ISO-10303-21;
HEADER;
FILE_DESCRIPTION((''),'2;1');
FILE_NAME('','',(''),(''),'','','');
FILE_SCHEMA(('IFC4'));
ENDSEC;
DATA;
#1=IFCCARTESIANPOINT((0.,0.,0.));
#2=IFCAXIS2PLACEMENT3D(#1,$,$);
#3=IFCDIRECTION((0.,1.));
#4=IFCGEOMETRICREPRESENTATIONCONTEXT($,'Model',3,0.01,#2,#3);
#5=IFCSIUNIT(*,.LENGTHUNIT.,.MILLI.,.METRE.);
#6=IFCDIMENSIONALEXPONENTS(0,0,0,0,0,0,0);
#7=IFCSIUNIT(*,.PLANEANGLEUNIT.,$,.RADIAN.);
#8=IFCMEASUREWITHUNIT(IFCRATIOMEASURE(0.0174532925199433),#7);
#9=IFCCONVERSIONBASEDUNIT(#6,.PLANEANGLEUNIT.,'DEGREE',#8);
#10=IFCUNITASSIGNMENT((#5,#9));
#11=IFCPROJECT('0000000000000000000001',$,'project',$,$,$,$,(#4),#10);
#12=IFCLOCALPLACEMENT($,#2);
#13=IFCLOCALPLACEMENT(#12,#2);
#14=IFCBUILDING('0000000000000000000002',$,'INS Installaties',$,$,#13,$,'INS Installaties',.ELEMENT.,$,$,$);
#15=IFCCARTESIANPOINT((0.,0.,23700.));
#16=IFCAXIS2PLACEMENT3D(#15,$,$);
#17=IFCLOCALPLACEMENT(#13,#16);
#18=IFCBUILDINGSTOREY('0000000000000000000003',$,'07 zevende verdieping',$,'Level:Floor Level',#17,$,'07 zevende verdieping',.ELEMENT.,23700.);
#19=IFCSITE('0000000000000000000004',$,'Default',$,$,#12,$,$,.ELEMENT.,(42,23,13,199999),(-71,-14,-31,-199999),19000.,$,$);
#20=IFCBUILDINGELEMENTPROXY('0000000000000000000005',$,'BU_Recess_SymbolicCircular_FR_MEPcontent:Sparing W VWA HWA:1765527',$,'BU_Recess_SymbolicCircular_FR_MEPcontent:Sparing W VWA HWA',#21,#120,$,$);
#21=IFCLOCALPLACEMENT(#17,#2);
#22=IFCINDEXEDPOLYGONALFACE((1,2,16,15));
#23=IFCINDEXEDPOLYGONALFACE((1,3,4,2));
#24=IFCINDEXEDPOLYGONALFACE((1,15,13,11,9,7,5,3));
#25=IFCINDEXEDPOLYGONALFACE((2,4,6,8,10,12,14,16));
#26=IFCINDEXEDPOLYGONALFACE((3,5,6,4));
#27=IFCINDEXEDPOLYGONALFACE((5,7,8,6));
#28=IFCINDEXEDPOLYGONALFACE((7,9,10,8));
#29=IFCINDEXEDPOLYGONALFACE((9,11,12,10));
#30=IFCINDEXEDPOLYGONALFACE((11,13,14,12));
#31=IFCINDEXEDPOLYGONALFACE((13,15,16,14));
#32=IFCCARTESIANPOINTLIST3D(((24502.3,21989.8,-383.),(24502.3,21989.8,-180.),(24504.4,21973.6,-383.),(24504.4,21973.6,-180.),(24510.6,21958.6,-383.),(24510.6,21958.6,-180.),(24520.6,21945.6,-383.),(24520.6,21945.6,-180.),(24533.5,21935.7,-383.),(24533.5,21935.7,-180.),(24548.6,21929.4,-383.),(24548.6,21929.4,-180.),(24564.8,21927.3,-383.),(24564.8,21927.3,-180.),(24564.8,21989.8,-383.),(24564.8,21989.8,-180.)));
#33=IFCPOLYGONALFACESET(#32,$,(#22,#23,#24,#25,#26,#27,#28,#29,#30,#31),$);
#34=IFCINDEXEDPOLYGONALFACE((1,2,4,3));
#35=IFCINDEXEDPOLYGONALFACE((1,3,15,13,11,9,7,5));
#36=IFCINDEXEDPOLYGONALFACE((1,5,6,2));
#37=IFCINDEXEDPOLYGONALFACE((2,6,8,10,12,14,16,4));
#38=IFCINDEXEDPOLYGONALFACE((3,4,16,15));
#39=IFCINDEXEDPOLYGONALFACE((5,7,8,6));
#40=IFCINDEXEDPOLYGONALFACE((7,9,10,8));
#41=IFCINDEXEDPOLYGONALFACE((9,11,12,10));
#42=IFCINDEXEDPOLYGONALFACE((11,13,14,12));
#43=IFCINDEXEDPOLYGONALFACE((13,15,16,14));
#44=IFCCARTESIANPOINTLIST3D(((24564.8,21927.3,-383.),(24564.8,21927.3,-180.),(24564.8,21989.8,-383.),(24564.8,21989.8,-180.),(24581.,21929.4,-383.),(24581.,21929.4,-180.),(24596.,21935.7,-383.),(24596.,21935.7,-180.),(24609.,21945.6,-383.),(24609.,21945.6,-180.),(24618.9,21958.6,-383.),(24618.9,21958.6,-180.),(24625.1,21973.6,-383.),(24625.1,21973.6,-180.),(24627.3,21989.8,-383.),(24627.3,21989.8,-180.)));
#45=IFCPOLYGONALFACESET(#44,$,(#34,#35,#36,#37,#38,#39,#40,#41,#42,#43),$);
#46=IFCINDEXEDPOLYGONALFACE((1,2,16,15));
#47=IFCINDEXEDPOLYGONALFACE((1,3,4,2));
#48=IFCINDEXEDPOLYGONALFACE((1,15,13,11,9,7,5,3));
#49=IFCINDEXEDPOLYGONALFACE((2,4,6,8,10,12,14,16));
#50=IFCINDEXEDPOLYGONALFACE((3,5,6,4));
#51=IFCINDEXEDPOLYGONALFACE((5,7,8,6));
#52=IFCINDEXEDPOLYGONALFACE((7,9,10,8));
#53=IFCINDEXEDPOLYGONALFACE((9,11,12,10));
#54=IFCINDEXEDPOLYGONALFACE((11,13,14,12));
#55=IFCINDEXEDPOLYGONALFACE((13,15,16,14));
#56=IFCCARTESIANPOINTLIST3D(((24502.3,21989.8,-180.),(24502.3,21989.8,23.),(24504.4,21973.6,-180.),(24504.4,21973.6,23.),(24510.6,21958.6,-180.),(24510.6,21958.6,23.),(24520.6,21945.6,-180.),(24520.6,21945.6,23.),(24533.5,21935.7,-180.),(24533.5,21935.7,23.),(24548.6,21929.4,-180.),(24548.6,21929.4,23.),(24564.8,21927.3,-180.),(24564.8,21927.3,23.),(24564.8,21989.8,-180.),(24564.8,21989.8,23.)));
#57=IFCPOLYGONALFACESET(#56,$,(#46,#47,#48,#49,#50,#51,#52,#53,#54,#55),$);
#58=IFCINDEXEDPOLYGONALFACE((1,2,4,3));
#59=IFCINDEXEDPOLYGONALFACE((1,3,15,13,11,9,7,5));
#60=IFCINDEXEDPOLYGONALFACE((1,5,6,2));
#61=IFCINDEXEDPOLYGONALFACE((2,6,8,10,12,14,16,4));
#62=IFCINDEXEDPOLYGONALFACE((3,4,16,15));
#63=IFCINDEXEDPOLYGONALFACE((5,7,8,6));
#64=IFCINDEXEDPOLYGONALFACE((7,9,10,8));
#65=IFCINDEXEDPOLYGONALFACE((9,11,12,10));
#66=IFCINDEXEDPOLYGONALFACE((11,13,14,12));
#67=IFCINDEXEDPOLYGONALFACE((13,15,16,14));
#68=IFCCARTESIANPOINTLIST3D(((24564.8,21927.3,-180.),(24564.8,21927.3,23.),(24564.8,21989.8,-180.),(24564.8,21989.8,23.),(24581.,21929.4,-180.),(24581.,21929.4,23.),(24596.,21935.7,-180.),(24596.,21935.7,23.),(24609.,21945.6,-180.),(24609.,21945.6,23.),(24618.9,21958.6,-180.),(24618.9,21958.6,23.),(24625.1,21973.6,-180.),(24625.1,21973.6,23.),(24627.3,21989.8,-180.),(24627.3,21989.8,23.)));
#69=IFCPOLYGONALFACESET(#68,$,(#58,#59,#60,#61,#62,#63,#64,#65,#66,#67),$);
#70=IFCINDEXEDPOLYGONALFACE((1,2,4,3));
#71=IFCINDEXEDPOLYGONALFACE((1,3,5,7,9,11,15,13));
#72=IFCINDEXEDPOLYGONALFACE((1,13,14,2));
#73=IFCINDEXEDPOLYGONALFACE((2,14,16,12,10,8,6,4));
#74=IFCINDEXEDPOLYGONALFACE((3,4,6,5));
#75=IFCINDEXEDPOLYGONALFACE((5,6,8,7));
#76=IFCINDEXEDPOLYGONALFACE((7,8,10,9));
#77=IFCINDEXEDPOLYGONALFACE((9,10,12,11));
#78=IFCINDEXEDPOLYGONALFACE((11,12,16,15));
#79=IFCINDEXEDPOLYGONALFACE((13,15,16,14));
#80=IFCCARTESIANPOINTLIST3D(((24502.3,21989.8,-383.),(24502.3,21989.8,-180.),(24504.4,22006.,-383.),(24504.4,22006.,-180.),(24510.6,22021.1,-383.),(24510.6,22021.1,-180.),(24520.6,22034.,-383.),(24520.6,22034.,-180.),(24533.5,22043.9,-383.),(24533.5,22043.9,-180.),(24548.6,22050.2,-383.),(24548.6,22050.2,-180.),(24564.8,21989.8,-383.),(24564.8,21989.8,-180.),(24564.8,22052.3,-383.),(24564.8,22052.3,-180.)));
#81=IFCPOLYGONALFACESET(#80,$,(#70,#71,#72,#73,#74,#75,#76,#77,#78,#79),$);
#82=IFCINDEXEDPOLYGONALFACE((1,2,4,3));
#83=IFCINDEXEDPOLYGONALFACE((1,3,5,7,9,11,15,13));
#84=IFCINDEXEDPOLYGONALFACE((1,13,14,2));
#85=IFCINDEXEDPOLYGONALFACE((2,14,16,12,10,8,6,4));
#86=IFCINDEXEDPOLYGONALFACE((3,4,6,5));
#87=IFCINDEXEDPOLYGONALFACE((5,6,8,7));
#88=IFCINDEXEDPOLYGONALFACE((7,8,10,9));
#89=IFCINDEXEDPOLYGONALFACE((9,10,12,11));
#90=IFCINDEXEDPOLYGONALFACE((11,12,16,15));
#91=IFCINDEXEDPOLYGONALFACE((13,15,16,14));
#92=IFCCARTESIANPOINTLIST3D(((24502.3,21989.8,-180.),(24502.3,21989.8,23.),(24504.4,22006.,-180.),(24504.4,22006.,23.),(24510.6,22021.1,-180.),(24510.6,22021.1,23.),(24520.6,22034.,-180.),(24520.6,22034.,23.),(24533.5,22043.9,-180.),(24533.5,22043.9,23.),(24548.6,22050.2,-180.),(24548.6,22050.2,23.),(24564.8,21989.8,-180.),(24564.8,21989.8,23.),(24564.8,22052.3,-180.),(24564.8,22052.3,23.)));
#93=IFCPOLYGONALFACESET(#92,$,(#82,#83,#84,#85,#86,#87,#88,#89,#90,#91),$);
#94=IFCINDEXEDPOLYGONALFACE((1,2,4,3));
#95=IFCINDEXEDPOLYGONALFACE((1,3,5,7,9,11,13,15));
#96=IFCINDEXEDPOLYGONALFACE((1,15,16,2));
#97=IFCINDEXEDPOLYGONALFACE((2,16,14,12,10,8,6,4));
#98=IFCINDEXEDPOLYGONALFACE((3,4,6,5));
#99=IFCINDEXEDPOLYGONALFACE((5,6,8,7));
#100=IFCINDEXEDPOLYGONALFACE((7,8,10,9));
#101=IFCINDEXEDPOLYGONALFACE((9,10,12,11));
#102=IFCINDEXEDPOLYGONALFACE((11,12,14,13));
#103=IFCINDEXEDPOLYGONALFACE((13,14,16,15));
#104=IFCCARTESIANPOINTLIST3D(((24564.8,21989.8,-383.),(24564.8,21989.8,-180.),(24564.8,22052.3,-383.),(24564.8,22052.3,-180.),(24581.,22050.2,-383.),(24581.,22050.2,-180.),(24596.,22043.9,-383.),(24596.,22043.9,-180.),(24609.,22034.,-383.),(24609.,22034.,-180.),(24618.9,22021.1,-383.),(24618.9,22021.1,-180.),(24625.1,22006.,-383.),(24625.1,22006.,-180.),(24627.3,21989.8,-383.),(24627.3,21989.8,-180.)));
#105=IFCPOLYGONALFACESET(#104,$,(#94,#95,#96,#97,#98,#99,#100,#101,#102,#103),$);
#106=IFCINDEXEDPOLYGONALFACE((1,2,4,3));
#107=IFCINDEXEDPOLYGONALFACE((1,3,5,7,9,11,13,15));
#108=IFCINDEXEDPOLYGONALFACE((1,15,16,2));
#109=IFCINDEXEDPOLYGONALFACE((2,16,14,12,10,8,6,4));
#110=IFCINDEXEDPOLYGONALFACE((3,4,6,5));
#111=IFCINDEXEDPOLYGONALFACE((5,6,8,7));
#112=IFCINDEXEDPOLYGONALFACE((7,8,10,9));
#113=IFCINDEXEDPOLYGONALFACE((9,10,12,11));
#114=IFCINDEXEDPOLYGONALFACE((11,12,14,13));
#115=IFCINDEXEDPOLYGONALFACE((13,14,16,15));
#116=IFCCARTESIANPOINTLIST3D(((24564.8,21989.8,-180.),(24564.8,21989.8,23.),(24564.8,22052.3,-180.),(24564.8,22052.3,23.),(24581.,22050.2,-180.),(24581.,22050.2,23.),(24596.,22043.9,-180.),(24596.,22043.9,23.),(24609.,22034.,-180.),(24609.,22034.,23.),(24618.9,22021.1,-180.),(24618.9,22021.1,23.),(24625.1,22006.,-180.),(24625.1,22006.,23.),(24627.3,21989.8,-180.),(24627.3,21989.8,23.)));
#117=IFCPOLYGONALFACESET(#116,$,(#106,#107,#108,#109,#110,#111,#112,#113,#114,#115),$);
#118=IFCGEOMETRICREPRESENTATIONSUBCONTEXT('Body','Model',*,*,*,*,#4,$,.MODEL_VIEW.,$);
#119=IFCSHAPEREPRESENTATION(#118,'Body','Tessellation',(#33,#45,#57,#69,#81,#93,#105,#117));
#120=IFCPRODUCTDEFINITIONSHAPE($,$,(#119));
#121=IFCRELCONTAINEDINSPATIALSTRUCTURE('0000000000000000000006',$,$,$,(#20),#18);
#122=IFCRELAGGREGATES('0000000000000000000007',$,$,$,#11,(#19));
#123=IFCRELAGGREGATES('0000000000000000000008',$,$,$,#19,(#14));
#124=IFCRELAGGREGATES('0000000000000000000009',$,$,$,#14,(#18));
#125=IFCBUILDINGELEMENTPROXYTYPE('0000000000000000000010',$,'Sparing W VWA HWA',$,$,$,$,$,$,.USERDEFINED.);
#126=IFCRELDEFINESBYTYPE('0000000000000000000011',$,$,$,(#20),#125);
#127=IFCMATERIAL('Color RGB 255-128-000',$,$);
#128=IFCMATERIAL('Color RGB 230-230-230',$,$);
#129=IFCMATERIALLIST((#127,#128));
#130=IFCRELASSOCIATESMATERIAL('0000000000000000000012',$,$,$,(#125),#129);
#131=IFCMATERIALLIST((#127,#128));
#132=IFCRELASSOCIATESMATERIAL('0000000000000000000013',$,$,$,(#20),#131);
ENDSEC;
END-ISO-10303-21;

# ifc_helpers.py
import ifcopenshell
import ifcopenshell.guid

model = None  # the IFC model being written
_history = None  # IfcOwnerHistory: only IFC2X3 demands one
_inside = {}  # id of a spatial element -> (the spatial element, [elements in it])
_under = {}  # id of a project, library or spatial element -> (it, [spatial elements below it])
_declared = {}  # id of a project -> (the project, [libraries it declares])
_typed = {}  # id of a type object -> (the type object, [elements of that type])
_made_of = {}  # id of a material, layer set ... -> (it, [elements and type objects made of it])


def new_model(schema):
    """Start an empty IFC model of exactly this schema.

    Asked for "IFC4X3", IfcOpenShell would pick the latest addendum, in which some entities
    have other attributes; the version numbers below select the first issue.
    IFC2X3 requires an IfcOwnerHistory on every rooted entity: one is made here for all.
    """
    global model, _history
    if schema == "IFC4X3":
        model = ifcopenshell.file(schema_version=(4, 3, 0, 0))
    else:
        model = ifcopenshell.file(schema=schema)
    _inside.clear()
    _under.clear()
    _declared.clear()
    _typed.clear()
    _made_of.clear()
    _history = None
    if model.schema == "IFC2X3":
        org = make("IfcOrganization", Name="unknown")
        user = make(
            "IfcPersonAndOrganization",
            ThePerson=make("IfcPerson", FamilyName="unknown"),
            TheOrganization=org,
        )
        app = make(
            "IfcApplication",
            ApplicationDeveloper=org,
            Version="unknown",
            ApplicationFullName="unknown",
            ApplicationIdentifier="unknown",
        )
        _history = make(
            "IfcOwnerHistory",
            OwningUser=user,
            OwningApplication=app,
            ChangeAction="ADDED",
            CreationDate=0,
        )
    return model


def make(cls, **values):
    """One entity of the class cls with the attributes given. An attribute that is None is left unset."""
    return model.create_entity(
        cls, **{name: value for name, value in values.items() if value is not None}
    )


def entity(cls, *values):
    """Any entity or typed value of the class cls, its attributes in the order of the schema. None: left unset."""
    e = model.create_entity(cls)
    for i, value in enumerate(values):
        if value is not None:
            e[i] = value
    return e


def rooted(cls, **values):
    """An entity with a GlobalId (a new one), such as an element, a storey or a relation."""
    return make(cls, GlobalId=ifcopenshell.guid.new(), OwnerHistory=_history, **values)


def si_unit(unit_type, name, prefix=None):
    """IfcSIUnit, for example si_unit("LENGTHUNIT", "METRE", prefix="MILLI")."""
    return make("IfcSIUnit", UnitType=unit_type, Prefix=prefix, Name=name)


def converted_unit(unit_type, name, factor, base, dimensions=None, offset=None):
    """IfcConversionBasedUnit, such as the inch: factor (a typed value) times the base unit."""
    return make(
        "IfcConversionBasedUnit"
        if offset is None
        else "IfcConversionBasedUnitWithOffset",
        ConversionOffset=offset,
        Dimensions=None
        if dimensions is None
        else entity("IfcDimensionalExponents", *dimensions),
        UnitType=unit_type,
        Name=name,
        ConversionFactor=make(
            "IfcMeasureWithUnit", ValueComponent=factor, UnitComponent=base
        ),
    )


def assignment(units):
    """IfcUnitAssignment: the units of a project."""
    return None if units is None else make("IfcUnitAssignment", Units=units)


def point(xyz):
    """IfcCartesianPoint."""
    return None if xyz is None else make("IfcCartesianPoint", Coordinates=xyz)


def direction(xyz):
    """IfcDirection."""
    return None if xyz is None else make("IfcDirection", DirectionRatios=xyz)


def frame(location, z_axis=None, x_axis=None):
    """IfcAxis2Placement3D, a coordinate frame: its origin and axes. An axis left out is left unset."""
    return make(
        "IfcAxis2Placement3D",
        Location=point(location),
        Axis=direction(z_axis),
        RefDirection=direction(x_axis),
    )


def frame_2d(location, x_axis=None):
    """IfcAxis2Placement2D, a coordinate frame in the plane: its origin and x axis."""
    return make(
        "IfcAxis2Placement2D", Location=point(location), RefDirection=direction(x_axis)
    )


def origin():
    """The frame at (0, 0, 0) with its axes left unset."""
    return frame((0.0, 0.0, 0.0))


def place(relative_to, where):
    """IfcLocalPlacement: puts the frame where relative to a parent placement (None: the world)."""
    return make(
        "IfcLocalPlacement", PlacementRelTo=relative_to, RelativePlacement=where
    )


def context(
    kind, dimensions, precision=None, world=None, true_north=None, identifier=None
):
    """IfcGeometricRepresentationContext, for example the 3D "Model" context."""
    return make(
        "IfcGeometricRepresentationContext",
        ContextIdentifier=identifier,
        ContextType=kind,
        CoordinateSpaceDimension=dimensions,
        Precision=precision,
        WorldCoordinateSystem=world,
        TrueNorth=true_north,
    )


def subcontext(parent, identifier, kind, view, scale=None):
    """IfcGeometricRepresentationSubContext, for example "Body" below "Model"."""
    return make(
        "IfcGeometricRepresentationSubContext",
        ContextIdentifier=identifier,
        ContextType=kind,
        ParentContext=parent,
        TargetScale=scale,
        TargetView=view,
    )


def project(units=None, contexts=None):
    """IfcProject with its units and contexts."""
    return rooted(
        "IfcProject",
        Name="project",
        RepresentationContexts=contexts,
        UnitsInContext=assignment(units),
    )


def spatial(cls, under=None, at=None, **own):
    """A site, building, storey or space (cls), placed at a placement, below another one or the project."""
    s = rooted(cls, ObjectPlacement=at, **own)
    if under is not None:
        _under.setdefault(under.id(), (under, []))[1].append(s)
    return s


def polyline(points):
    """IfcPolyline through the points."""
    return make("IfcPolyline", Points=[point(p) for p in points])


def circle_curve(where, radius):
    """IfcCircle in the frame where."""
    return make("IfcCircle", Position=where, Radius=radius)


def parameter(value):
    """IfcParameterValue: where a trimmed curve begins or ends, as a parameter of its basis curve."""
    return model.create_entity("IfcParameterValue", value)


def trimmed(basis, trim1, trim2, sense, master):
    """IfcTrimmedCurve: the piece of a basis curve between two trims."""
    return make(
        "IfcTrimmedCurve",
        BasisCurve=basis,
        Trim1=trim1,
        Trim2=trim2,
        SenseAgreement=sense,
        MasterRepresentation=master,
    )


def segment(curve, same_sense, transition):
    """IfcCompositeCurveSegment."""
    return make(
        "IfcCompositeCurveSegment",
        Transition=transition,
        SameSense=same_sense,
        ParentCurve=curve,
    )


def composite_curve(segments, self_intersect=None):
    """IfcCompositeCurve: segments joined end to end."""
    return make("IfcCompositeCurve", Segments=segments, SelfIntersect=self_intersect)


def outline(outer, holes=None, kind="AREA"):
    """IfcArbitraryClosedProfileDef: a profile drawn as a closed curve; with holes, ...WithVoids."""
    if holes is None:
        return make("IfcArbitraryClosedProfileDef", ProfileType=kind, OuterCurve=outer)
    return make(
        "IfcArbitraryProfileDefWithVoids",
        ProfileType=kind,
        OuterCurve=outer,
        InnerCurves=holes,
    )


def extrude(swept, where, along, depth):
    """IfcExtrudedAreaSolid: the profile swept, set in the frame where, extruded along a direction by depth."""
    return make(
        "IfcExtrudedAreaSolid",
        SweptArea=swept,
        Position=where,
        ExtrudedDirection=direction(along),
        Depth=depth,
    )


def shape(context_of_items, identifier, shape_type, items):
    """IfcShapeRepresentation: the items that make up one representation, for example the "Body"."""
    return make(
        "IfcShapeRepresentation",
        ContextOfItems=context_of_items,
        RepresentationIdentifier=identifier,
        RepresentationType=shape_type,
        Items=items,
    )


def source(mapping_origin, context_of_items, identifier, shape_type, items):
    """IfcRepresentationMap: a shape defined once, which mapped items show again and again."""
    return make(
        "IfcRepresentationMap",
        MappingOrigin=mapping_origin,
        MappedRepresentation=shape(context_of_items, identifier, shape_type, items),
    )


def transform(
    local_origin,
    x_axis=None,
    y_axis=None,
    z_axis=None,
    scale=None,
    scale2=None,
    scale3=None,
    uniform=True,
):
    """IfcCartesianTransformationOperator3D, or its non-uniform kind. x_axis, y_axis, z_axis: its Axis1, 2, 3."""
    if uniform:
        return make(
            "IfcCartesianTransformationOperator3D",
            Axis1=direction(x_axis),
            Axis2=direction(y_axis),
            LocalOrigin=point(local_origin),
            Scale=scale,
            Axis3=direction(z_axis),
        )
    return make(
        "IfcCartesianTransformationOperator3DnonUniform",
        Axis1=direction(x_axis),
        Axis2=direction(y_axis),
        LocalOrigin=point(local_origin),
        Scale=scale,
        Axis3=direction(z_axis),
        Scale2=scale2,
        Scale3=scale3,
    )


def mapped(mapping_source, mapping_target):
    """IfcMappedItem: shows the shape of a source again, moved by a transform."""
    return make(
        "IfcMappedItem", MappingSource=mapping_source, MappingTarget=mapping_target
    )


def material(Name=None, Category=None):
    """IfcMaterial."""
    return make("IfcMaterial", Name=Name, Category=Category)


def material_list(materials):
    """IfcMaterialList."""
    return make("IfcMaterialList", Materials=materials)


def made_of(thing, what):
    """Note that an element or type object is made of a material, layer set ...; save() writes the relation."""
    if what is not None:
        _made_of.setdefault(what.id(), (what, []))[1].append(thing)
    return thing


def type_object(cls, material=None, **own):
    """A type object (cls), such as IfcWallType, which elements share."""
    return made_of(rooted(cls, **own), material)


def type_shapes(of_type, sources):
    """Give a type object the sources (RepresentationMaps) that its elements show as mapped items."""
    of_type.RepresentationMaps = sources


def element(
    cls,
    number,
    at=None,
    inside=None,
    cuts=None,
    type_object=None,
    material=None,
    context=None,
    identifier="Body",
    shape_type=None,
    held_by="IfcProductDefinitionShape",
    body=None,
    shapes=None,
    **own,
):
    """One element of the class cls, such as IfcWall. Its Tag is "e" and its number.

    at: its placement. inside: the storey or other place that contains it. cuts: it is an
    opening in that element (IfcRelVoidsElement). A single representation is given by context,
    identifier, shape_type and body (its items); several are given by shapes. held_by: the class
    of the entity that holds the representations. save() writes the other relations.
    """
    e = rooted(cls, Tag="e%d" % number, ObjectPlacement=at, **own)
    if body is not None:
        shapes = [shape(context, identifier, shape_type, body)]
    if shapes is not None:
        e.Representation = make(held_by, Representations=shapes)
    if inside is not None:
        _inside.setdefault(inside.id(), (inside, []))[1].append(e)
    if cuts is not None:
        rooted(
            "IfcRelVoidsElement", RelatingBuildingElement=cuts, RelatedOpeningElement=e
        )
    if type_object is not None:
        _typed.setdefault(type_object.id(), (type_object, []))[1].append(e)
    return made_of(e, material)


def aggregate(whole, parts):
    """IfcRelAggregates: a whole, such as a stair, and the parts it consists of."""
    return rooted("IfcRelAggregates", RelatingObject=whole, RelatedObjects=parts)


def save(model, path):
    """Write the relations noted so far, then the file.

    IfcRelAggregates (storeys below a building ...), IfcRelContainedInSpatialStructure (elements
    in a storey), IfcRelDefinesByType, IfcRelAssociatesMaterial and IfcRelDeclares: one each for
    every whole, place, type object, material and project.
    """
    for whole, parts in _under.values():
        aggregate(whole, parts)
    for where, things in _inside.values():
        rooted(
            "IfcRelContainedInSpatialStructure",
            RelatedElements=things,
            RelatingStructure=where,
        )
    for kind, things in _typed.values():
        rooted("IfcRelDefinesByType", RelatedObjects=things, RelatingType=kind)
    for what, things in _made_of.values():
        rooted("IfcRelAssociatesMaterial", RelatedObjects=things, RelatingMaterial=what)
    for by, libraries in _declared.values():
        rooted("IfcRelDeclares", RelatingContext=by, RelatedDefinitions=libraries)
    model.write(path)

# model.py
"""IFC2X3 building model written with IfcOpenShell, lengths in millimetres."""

from ifc_helpers import new_model, entity, si_unit, converted_unit, direction, frame, frame_2d, origin, place, context, subcontext, project, spatial, polyline, circle_curve, parameter, trimmed, segment, composite_curve, outline, extrude, source, transform, mapped, material, material_list, type_object, type_shapes, element, save


model = new_model("IFC2X3")

# Units and contexts
model_context = context("Model", 3, precision=0.01, world=origin(), true_north=direction((0.0, 1.0)))
body_context = subcontext(model_context, "Body", "Model", "MODEL_VIEW")
ifc_project = project(units=[si_unit("LENGTHUNIT", "METRE", prefix="MILLI"), converted_unit("PLANEANGLEUNIT", "DEGREE", entity("IfcRatioMeasure", 0.0174532925199433), si_unit("PLANEANGLEUNIT", "RADIAN"), dimensions=[0, 0, 0, 0, 0, 0, 0])], contexts=[model_context])

# Site, building, storey
site_placement = place(None, origin())
site = spatial("IfcSite", under=ifc_project, at=site_placement, Name="Default", CompositionType="ELEMENT", RefLatitude=(42, 23, 13, 199999), RefLongitude=(-71, -14, -31, -199999), RefElevation=19000.0)
building_placement = place(site_placement, origin())
building = spatial("IfcBuilding", under=site, at=building_placement, Name="INS Installaties", LongName="INS Installaties", CompositionType="ELEMENT")
storey_placement = place(building_placement, frame((0.0, 0.0, 23700.0)))
storey = spatial("IfcBuildingStorey", under=building, at=storey_placement, Name="07 zevende verdieping", ObjectType="Level:Floor Level", LongName="07 zevende verdieping", CompositionType="ELEMENT", Elevation=23700.0)

# Building element proxy
ifc_material_1 = material(Name="Color RGB 255-128-000")
ifc_material_2 = material(Name="Color RGB 230-230-230")
ifc_material_list_1 = material_list([ifc_material_1, ifc_material_2])
ifc_material_list_2 = material_list([ifc_material_1, ifc_material_2])
building_element_proxy_type_1 = type_object("IfcBuildingElementProxyType", Name="Sparing W VWA HWA", PredefinedType="USERDEFINED", material=ifc_material_list_2)
shared_shape_1 = source(origin(), body_context, "Body", "SweptSolid", [
    extrude(outline(composite_curve([segment(trimmed(circle_curve(frame_2d((20.8, 20.8), x_axis=(1.0, 0.0)), 62.5), [parameter(180.0)], [parameter(270.0)], True, "PARAMETER"), True, "CONTINUOUS"), segment(polyline([(20.8, -41.7), (20.8, 20.8)]), True, "CONTINUOUS"), segment(polyline([(20.8, 20.8), (-41.7, 20.8)]), True, "CONTINUOUS")], self_intersect=False)), frame((20.8, 20.8, -403.0), z_axis=(0.0, 0.0, 1.0), x_axis=(-1.0, 0.0, 0.0)), (0.0, 0.0, 1.0), 203.0),
    extrude(outline(composite_curve([segment(polyline([(-41.7, -20.8), (20.8, -20.8)]), True, "CONTINUOUS"), segment(polyline([(20.8, -20.8), (20.8, 41.7)]), True, "CONTINUOUS"), segment(trimmed(circle_curve(frame_2d((20.8, -20.8), x_axis=(1.0, 0.0)), 62.5), [parameter(90.0)], [parameter(180.0)], True, "PARAMETER"), True, "CONTINUOUS")], self_intersect=False)), frame((-20.8, 20.8, -403.0)), (0.0, 0.0, 1.0), 203.0),
    extrude(outline(composite_curve([segment(trimmed(circle_curve(frame_2d((20.8, 20.8), x_axis=(1.0, 0.0)), 62.5), [parameter(180.0)], [parameter(270.0)], True, "PARAMETER"), True, "CONTINUOUS"), segment(polyline([(20.8, -41.7), (20.8, 20.8)]), True, "CONTINUOUS"), segment(polyline([(20.8, 20.8), (-41.7, 20.8)]), True, "CONTINUOUS")], self_intersect=False)), frame((20.8, 20.8, -200.0), z_axis=(0.0, 0.0, 1.0), x_axis=(-1.0, 0.0, 0.0)), (0.0, 0.0, 1.0), 203.0),
    extrude(outline(composite_curve([segment(polyline([(-41.7, -20.8), (20.8, -20.8)]), True, "CONTINUOUS"), segment(polyline([(20.8, -20.8), (20.8, 41.7)]), True, "CONTINUOUS"), segment(trimmed(circle_curve(frame_2d((20.8, -20.8), x_axis=(1.0, 0.0)), 62.5), [parameter(90.0)], [parameter(180.0)], True, "PARAMETER"), True, "CONTINUOUS")], self_intersect=False)), frame((-20.8, 20.8, -200.0)), (0.0, 0.0, 1.0), 203.0),
    extrude(outline(composite_curve([segment(polyline([(-41.7, -20.8), (20.8, -20.8)]), True, "CONTINUOUS"), segment(polyline([(20.8, -20.8), (20.8, 41.7)]), True, "CONTINUOUS"), segment(trimmed(circle_curve(frame_2d((20.8, -20.8), x_axis=(1.0, 0.0)), 62.5), [parameter(90.0)], [parameter(180.0)], True, "PARAMETER"), True, "CONTINUOUS")], self_intersect=False)), frame((20.8, -20.8, -403.0), z_axis=(0.0, 0.0, 1.0), x_axis=(-1.0, 0.0, 0.0)), (0.0, 0.0, 1.0), 203.0),
    extrude(outline(composite_curve([segment(polyline([(-41.7, -20.8), (20.8, -20.8)]), True, "CONTINUOUS"), segment(polyline([(20.8, -20.8), (20.8, 41.7)]), True, "CONTINUOUS"), segment(trimmed(circle_curve(frame_2d((20.8, -20.8), x_axis=(1.0, 0.0)), 62.5), [parameter(90.0)], [parameter(180.0)], True, "PARAMETER"), True, "CONTINUOUS")], self_intersect=False)), frame((20.8, -20.8, -200.0), z_axis=(0.0, 0.0, 1.0), x_axis=(-1.0, 0.0, 0.0)), (0.0, 0.0, 1.0), 203.0),
    extrude(outline(composite_curve([segment(trimmed(circle_curve(frame_2d((20.8, 20.8), x_axis=(1.0, 0.0)), 62.5), [parameter(180.0)], [parameter(270.0)], True, "PARAMETER"), True, "CONTINUOUS"), segment(polyline([(20.8, -41.7), (20.8, 20.8)]), True, "CONTINUOUS"), segment(polyline([(20.8, 20.8), (-41.7, 20.8)]), True, "CONTINUOUS")], self_intersect=False)), frame((-20.8, -20.8, -403.0)), (0.0, 0.0, 1.0), 203.0),
    extrude(outline(composite_curve([segment(trimmed(circle_curve(frame_2d((20.8, 20.8), x_axis=(1.0, 0.0)), 62.5), [parameter(180.0)], [parameter(270.0)], True, "PARAMETER"), True, "CONTINUOUS"), segment(polyline([(20.8, -41.7), (20.8, 20.8)]), True, "CONTINUOUS"), segment(polyline([(20.8, 20.8), (-41.7, 20.8)]), True, "CONTINUOUS")], self_intersect=False)), frame((-20.8, -20.8, -200.0)), (0.0, 0.0, 1.0), 203.0),
])
type_shapes(building_element_proxy_type_1, [shared_shape_1])
proxy_1_placement = place(storey_placement, frame((24564.8, 21989.8, 20.0), z_axis=(0.0, 0.0, 1.0), x_axis=(-1.0, 0.0, 0.0)))
element("IfcBuildingElementProxy", 1, at=proxy_1_placement, inside=storey, type_object=building_element_proxy_type_1, material=ifc_material_list_1, Name="BU_Recess_SymbolicCircular_FR_MEPcontent:Sparing W VWA HWA:1765527", ObjectType="BU_Recess_SymbolicCircular_FR_MEPcontent:Sparing W VWA HWA", context=body_context, shape_type="MappedRepresentation", body=[
    mapped(shared_shape_1, transform((0.0, 0.0, 0.0), scale=1.0)),
])

save(model, "model.ifc")
